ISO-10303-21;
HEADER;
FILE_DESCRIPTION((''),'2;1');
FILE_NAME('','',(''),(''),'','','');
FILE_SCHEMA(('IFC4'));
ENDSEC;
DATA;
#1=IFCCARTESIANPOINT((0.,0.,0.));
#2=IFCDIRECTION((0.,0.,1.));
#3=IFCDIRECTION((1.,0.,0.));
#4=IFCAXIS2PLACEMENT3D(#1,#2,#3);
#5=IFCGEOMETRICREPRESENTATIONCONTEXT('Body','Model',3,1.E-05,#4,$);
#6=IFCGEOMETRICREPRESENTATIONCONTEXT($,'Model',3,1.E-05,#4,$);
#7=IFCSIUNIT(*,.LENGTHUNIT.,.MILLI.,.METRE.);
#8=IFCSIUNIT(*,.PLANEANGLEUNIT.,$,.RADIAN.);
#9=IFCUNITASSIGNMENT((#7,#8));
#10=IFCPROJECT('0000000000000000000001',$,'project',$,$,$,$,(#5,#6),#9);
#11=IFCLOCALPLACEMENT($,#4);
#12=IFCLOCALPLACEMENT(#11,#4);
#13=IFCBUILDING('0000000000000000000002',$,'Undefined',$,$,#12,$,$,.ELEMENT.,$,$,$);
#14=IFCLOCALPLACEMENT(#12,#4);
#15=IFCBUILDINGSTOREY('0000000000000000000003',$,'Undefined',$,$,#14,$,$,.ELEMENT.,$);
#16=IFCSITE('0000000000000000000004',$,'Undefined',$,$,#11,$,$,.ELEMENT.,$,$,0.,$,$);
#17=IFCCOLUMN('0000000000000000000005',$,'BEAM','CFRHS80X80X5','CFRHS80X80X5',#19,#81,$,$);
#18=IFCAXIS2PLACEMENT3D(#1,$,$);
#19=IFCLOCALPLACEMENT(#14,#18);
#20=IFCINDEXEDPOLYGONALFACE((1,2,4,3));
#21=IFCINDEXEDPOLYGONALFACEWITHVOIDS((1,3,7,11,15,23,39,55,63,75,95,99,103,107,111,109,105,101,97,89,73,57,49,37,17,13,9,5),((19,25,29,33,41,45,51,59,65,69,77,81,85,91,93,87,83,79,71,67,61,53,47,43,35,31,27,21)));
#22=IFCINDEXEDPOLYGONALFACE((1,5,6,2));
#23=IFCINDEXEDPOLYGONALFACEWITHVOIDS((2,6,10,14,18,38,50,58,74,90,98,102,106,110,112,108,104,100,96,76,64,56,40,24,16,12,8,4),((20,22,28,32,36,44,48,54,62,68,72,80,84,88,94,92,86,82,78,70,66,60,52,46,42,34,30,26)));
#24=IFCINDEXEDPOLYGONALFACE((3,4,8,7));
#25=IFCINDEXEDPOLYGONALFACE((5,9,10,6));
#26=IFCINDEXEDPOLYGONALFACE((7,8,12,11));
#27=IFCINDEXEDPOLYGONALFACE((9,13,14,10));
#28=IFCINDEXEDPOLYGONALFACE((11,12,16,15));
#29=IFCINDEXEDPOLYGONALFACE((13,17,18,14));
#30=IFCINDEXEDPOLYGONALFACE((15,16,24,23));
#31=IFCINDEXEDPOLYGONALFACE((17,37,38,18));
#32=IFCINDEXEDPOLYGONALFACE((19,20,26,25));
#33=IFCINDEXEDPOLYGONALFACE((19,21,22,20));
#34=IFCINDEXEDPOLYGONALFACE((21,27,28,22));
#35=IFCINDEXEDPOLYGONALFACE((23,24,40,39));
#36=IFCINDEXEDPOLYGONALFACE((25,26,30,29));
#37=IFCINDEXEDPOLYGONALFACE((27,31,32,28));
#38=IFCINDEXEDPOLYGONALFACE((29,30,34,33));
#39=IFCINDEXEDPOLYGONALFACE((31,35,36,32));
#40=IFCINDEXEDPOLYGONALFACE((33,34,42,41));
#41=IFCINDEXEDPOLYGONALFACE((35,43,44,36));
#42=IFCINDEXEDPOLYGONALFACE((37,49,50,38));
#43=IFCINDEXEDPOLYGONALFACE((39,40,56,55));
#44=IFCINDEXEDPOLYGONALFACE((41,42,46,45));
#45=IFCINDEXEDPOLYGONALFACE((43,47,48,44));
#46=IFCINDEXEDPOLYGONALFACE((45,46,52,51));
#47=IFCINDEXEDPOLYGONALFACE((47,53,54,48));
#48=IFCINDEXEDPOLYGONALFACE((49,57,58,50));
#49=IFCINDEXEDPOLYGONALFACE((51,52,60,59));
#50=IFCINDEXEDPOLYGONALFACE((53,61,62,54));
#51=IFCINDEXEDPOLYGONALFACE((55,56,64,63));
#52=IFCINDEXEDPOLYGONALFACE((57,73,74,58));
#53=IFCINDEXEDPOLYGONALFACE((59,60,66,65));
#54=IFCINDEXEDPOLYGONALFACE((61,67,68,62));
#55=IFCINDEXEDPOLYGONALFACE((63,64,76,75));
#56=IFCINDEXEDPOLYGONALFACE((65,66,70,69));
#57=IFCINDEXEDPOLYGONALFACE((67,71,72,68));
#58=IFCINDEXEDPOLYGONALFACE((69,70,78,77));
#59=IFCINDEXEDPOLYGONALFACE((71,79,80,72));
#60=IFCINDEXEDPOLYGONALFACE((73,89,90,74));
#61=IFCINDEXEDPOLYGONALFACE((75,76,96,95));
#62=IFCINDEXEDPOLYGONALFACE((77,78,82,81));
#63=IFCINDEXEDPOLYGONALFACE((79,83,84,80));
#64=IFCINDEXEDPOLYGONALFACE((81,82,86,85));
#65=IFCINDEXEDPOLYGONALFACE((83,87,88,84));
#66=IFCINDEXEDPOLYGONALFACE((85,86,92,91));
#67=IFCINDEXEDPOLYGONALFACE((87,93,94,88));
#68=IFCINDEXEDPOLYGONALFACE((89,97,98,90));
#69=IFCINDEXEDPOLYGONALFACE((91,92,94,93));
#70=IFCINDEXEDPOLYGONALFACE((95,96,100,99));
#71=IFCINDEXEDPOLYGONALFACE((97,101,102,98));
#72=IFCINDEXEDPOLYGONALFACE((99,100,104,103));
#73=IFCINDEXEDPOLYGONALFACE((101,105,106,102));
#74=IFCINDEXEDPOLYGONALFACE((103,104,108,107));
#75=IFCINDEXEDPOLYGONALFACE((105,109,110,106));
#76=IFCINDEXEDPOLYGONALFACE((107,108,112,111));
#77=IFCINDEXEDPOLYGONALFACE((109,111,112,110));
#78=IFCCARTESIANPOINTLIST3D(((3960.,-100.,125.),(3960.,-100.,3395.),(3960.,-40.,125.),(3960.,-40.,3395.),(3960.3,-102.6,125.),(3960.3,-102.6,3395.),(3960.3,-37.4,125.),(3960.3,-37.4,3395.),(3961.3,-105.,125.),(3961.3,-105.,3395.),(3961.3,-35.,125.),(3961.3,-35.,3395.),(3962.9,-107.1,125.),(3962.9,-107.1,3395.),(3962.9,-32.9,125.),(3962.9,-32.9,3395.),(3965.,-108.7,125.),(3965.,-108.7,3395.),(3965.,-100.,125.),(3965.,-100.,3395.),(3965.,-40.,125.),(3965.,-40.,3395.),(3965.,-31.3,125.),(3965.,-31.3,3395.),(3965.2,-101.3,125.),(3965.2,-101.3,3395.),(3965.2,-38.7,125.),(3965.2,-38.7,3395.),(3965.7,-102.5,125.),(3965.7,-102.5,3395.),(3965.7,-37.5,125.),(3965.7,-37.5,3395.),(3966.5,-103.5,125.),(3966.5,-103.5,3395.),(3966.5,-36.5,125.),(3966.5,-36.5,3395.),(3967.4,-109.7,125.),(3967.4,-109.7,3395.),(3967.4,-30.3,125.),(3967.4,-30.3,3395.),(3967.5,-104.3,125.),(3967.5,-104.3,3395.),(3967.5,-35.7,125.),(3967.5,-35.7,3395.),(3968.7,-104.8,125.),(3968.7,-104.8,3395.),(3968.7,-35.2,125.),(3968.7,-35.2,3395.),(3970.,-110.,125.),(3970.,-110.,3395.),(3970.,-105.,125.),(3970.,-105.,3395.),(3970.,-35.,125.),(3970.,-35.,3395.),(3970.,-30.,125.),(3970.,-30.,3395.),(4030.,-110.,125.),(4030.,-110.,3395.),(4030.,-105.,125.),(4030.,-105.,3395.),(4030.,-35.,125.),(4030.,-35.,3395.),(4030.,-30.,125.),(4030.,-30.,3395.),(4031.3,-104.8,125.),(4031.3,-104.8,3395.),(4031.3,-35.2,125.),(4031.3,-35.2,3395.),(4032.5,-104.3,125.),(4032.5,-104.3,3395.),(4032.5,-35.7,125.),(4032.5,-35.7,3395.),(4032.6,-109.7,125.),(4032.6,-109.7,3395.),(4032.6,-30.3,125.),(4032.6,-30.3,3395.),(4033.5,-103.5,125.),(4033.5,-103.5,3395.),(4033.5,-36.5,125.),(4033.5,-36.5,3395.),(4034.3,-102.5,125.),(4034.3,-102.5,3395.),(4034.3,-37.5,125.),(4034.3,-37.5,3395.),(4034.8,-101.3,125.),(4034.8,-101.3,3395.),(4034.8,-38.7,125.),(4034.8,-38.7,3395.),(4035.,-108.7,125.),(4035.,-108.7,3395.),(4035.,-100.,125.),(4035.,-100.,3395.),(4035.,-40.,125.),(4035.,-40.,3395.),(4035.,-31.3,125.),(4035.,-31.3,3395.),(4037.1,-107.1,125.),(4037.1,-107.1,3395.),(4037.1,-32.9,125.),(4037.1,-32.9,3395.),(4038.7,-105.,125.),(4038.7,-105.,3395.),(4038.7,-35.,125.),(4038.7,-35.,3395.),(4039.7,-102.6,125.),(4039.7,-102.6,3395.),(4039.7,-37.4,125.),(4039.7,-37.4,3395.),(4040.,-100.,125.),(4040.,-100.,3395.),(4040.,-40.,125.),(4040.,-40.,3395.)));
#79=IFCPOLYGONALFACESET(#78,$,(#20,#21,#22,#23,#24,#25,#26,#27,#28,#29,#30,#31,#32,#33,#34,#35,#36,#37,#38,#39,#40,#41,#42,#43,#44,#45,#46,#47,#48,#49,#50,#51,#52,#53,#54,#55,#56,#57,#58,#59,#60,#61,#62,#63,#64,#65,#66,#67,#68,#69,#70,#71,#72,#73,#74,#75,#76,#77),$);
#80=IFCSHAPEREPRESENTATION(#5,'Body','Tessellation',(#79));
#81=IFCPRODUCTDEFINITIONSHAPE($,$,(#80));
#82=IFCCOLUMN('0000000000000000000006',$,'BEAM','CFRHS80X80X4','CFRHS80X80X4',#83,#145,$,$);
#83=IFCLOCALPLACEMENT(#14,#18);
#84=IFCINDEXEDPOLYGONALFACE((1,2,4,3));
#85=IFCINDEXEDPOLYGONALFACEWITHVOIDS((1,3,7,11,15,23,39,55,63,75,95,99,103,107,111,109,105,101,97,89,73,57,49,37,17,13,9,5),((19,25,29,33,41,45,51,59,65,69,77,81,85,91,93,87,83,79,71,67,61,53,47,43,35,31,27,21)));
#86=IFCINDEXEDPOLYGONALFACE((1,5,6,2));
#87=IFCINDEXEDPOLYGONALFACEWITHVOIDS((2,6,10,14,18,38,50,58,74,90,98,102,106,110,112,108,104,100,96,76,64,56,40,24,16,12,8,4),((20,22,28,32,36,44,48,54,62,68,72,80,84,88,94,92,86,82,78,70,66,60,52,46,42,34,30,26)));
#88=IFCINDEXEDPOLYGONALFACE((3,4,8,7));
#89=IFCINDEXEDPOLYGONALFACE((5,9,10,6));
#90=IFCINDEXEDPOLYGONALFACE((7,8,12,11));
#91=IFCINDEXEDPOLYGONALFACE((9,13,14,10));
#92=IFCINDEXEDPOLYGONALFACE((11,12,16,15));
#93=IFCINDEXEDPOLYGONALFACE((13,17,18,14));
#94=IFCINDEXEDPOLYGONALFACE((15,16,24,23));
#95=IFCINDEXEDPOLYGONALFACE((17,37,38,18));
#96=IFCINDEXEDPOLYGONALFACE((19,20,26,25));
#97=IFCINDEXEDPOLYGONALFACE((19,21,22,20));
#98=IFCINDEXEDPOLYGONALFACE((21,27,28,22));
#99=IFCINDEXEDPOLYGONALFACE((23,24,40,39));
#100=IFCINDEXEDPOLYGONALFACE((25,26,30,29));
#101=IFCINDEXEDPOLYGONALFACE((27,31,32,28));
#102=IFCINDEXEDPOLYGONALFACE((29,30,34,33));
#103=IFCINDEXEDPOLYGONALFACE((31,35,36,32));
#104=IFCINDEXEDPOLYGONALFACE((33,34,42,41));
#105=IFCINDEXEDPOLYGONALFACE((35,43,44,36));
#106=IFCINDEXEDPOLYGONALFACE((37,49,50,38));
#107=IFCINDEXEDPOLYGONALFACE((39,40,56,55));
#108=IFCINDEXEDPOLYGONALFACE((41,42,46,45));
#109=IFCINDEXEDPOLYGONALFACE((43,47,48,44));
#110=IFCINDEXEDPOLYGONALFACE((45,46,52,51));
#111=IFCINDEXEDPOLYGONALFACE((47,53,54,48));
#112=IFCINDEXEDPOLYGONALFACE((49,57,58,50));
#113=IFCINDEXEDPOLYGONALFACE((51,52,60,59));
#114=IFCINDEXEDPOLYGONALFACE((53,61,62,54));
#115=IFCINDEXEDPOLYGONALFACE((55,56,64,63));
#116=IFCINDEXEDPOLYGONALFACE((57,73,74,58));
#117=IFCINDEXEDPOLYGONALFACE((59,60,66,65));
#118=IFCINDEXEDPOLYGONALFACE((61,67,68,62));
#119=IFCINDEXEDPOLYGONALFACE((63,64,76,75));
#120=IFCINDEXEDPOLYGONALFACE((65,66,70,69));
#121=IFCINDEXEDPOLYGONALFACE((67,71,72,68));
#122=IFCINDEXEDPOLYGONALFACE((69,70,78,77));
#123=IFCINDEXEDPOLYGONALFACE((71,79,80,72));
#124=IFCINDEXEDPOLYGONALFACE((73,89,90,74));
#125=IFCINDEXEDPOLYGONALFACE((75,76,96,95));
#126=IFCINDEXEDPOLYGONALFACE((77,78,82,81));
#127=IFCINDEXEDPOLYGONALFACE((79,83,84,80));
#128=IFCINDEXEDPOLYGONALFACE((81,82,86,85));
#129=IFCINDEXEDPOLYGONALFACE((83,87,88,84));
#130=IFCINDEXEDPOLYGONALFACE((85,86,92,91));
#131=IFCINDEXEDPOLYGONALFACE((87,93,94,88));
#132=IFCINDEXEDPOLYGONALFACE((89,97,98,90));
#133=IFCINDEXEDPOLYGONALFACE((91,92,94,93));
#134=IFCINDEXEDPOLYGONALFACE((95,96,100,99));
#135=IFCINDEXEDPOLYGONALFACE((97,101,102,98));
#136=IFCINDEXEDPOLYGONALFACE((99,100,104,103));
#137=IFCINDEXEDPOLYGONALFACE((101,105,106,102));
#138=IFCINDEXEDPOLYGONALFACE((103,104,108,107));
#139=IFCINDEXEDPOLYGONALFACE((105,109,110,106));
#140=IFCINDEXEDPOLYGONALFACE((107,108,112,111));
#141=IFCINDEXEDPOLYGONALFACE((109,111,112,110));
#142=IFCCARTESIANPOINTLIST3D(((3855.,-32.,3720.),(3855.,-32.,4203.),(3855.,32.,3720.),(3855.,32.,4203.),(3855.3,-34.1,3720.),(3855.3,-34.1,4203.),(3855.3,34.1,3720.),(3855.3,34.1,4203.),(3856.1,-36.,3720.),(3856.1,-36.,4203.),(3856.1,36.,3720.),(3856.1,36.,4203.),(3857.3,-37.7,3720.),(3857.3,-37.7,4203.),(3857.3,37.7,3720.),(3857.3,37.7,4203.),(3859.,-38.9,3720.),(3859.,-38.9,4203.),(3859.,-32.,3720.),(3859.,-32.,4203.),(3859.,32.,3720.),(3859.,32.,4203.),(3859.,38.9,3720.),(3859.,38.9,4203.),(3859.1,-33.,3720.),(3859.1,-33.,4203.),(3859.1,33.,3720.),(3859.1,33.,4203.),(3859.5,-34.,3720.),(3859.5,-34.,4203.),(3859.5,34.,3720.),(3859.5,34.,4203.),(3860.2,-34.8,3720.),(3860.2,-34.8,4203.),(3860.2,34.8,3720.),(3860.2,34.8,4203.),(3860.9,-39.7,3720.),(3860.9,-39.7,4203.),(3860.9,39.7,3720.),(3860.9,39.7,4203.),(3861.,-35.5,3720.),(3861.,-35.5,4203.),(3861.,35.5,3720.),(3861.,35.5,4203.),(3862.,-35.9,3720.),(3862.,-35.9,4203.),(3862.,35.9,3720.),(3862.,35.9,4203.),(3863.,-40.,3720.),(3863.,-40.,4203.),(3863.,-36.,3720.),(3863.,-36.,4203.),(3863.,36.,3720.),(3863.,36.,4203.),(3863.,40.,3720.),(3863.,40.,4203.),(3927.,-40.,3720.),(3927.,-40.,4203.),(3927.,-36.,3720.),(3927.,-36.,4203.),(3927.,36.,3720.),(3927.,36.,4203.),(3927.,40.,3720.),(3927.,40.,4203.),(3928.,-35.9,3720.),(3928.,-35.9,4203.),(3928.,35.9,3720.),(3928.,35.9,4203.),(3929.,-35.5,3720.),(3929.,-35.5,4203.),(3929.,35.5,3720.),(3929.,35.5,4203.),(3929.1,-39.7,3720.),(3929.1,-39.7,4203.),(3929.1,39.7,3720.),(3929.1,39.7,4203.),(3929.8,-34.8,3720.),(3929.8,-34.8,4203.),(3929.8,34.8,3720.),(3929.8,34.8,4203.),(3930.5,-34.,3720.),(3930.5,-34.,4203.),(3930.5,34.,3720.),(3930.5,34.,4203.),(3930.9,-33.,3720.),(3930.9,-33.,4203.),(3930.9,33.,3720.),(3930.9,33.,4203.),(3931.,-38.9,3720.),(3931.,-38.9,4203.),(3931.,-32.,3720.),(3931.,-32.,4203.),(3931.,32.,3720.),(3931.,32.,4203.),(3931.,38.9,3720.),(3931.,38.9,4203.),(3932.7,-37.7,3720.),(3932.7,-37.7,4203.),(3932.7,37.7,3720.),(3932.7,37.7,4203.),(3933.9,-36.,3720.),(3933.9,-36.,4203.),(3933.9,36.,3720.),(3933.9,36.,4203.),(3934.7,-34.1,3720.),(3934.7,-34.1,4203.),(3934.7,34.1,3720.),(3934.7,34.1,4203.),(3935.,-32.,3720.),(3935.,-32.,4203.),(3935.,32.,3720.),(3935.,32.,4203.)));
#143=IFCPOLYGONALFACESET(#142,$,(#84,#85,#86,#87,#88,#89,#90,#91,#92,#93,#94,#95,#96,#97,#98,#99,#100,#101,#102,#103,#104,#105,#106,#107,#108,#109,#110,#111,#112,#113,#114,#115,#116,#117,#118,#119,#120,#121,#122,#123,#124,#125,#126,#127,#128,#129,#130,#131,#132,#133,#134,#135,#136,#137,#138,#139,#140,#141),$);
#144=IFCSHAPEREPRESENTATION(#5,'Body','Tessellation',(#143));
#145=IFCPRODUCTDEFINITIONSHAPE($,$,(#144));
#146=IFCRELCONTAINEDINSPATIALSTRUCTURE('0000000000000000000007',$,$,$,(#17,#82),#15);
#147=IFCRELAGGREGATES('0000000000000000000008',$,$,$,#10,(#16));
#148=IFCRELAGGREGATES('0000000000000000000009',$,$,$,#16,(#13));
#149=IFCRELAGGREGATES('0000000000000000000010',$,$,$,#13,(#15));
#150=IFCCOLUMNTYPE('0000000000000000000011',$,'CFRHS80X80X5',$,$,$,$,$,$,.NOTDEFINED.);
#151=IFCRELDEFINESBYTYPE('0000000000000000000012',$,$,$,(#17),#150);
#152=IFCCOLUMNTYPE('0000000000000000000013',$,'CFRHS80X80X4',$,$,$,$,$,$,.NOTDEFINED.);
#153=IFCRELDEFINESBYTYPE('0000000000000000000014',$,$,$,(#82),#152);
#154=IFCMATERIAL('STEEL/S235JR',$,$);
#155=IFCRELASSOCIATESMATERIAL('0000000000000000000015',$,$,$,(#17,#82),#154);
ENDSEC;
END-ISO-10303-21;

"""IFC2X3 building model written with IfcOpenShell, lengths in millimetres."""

from ifc_helpers import new_model, si_unit, frame, origin_with_axes, origin_2d_with_axis, place, context, project, spatial, hollow_rectangle, extrude, material, type_object, element, save


model = new_model("IFC2X3")

# Units and contexts
model_context_1 = context("Model", 3, precision=1e-05, world=origin_with_axes(), identifier="Body")
model_context_2 = context("Model", 3, precision=1e-05, world=origin_with_axes())
ifc_project = project(units=[si_unit("LENGTHUNIT", "METRE", prefix="MILLI"), si_unit("PLANEANGLEUNIT", "RADIAN")], contexts=[model_context_1, model_context_2])

# Site, building, storey
site_placement = place(None, origin_with_axes())
site = spatial("IfcSite", under=ifc_project, at=site_placement, Name="Undefined", CompositionType="ELEMENT", RefElevation=0.0)
building_placement = place(site_placement, origin_with_axes())
building = spatial("IfcBuilding", under=site, at=building_placement, Name="Undefined", CompositionType="ELEMENT")
storey_placement = place(building_placement, origin_with_axes())
storey = spatial("IfcBuildingStorey", under=building, at=storey_placement, Name="Undefined", CompositionType="ELEMENT")

# Columns
ifc_material = material(Name="STEEL/S235JR")
column_type_1 = type_object("IfcColumnType", Name="CFRHS80X80X5", PredefinedType="NOTDEFINED")
column_1_placement = place(storey_placement, frame((4000.0, -70.0, 125.0), z_axis=(0.0, 0.0, 1.0), x_axis=(1.0, 0.0, 0.0)))
element("IfcColumn", 1, at=column_1_placement, inside=storey, type_object=column_type_1, material=ifc_material, Name="BEAM", Description="CFRHS80X80X5", ObjectType="CFRHS80X80X5", context=model_context_1, shape_type="SweptSolid", body=[
    extrude(hollow_rectangle(XDim=80.0, YDim=80.0, WallThickness=5.0, InnerFilletRadius=5.0, OuterFilletRadius=10.0, at=origin_2d_with_axis()), frame((0.0, 0.0, 3270.0), z_axis=(0.0, 0.0, -1.0), x_axis=(1.0, 0.0, 0.0)), (0.0, 0.0, 1.0), 3270.0),
])
column_type_2 = type_object("IfcColumnType", Name="CFRHS80X80X4", PredefinedType="NOTDEFINED")
for number, where, z_axis, x_axis, name in (
    (2, (3895.0, 0.0, 3720.0), (0.0, 0.0, 1.0), (1.0, 0.0, 0.0), "BEAM"),
):
    element("IfcColumn", number, at=place(storey_placement, frame(where, z_axis=z_axis, x_axis=x_axis)), inside=storey, type_object=column_type_2, material=ifc_material, Name=name, Description="CFRHS80X80X4", ObjectType="CFRHS80X80X4", context=model_context_1, shape_type="SweptSolid", body=[
        extrude(hollow_rectangle(XDim=80.0, YDim=80.0, WallThickness=4.0, InnerFilletRadius=4.0, OuterFilletRadius=8.0, at=origin_2d_with_axis()), frame((0.0, 0.0, 483.0), z_axis=(0.0, 0.0, -1.0), x_axis=(0.0, 1.0, 0.0)), (0.0, 0.0, 1.0), 483.0),
    ])

save(model, "model.ifc")
